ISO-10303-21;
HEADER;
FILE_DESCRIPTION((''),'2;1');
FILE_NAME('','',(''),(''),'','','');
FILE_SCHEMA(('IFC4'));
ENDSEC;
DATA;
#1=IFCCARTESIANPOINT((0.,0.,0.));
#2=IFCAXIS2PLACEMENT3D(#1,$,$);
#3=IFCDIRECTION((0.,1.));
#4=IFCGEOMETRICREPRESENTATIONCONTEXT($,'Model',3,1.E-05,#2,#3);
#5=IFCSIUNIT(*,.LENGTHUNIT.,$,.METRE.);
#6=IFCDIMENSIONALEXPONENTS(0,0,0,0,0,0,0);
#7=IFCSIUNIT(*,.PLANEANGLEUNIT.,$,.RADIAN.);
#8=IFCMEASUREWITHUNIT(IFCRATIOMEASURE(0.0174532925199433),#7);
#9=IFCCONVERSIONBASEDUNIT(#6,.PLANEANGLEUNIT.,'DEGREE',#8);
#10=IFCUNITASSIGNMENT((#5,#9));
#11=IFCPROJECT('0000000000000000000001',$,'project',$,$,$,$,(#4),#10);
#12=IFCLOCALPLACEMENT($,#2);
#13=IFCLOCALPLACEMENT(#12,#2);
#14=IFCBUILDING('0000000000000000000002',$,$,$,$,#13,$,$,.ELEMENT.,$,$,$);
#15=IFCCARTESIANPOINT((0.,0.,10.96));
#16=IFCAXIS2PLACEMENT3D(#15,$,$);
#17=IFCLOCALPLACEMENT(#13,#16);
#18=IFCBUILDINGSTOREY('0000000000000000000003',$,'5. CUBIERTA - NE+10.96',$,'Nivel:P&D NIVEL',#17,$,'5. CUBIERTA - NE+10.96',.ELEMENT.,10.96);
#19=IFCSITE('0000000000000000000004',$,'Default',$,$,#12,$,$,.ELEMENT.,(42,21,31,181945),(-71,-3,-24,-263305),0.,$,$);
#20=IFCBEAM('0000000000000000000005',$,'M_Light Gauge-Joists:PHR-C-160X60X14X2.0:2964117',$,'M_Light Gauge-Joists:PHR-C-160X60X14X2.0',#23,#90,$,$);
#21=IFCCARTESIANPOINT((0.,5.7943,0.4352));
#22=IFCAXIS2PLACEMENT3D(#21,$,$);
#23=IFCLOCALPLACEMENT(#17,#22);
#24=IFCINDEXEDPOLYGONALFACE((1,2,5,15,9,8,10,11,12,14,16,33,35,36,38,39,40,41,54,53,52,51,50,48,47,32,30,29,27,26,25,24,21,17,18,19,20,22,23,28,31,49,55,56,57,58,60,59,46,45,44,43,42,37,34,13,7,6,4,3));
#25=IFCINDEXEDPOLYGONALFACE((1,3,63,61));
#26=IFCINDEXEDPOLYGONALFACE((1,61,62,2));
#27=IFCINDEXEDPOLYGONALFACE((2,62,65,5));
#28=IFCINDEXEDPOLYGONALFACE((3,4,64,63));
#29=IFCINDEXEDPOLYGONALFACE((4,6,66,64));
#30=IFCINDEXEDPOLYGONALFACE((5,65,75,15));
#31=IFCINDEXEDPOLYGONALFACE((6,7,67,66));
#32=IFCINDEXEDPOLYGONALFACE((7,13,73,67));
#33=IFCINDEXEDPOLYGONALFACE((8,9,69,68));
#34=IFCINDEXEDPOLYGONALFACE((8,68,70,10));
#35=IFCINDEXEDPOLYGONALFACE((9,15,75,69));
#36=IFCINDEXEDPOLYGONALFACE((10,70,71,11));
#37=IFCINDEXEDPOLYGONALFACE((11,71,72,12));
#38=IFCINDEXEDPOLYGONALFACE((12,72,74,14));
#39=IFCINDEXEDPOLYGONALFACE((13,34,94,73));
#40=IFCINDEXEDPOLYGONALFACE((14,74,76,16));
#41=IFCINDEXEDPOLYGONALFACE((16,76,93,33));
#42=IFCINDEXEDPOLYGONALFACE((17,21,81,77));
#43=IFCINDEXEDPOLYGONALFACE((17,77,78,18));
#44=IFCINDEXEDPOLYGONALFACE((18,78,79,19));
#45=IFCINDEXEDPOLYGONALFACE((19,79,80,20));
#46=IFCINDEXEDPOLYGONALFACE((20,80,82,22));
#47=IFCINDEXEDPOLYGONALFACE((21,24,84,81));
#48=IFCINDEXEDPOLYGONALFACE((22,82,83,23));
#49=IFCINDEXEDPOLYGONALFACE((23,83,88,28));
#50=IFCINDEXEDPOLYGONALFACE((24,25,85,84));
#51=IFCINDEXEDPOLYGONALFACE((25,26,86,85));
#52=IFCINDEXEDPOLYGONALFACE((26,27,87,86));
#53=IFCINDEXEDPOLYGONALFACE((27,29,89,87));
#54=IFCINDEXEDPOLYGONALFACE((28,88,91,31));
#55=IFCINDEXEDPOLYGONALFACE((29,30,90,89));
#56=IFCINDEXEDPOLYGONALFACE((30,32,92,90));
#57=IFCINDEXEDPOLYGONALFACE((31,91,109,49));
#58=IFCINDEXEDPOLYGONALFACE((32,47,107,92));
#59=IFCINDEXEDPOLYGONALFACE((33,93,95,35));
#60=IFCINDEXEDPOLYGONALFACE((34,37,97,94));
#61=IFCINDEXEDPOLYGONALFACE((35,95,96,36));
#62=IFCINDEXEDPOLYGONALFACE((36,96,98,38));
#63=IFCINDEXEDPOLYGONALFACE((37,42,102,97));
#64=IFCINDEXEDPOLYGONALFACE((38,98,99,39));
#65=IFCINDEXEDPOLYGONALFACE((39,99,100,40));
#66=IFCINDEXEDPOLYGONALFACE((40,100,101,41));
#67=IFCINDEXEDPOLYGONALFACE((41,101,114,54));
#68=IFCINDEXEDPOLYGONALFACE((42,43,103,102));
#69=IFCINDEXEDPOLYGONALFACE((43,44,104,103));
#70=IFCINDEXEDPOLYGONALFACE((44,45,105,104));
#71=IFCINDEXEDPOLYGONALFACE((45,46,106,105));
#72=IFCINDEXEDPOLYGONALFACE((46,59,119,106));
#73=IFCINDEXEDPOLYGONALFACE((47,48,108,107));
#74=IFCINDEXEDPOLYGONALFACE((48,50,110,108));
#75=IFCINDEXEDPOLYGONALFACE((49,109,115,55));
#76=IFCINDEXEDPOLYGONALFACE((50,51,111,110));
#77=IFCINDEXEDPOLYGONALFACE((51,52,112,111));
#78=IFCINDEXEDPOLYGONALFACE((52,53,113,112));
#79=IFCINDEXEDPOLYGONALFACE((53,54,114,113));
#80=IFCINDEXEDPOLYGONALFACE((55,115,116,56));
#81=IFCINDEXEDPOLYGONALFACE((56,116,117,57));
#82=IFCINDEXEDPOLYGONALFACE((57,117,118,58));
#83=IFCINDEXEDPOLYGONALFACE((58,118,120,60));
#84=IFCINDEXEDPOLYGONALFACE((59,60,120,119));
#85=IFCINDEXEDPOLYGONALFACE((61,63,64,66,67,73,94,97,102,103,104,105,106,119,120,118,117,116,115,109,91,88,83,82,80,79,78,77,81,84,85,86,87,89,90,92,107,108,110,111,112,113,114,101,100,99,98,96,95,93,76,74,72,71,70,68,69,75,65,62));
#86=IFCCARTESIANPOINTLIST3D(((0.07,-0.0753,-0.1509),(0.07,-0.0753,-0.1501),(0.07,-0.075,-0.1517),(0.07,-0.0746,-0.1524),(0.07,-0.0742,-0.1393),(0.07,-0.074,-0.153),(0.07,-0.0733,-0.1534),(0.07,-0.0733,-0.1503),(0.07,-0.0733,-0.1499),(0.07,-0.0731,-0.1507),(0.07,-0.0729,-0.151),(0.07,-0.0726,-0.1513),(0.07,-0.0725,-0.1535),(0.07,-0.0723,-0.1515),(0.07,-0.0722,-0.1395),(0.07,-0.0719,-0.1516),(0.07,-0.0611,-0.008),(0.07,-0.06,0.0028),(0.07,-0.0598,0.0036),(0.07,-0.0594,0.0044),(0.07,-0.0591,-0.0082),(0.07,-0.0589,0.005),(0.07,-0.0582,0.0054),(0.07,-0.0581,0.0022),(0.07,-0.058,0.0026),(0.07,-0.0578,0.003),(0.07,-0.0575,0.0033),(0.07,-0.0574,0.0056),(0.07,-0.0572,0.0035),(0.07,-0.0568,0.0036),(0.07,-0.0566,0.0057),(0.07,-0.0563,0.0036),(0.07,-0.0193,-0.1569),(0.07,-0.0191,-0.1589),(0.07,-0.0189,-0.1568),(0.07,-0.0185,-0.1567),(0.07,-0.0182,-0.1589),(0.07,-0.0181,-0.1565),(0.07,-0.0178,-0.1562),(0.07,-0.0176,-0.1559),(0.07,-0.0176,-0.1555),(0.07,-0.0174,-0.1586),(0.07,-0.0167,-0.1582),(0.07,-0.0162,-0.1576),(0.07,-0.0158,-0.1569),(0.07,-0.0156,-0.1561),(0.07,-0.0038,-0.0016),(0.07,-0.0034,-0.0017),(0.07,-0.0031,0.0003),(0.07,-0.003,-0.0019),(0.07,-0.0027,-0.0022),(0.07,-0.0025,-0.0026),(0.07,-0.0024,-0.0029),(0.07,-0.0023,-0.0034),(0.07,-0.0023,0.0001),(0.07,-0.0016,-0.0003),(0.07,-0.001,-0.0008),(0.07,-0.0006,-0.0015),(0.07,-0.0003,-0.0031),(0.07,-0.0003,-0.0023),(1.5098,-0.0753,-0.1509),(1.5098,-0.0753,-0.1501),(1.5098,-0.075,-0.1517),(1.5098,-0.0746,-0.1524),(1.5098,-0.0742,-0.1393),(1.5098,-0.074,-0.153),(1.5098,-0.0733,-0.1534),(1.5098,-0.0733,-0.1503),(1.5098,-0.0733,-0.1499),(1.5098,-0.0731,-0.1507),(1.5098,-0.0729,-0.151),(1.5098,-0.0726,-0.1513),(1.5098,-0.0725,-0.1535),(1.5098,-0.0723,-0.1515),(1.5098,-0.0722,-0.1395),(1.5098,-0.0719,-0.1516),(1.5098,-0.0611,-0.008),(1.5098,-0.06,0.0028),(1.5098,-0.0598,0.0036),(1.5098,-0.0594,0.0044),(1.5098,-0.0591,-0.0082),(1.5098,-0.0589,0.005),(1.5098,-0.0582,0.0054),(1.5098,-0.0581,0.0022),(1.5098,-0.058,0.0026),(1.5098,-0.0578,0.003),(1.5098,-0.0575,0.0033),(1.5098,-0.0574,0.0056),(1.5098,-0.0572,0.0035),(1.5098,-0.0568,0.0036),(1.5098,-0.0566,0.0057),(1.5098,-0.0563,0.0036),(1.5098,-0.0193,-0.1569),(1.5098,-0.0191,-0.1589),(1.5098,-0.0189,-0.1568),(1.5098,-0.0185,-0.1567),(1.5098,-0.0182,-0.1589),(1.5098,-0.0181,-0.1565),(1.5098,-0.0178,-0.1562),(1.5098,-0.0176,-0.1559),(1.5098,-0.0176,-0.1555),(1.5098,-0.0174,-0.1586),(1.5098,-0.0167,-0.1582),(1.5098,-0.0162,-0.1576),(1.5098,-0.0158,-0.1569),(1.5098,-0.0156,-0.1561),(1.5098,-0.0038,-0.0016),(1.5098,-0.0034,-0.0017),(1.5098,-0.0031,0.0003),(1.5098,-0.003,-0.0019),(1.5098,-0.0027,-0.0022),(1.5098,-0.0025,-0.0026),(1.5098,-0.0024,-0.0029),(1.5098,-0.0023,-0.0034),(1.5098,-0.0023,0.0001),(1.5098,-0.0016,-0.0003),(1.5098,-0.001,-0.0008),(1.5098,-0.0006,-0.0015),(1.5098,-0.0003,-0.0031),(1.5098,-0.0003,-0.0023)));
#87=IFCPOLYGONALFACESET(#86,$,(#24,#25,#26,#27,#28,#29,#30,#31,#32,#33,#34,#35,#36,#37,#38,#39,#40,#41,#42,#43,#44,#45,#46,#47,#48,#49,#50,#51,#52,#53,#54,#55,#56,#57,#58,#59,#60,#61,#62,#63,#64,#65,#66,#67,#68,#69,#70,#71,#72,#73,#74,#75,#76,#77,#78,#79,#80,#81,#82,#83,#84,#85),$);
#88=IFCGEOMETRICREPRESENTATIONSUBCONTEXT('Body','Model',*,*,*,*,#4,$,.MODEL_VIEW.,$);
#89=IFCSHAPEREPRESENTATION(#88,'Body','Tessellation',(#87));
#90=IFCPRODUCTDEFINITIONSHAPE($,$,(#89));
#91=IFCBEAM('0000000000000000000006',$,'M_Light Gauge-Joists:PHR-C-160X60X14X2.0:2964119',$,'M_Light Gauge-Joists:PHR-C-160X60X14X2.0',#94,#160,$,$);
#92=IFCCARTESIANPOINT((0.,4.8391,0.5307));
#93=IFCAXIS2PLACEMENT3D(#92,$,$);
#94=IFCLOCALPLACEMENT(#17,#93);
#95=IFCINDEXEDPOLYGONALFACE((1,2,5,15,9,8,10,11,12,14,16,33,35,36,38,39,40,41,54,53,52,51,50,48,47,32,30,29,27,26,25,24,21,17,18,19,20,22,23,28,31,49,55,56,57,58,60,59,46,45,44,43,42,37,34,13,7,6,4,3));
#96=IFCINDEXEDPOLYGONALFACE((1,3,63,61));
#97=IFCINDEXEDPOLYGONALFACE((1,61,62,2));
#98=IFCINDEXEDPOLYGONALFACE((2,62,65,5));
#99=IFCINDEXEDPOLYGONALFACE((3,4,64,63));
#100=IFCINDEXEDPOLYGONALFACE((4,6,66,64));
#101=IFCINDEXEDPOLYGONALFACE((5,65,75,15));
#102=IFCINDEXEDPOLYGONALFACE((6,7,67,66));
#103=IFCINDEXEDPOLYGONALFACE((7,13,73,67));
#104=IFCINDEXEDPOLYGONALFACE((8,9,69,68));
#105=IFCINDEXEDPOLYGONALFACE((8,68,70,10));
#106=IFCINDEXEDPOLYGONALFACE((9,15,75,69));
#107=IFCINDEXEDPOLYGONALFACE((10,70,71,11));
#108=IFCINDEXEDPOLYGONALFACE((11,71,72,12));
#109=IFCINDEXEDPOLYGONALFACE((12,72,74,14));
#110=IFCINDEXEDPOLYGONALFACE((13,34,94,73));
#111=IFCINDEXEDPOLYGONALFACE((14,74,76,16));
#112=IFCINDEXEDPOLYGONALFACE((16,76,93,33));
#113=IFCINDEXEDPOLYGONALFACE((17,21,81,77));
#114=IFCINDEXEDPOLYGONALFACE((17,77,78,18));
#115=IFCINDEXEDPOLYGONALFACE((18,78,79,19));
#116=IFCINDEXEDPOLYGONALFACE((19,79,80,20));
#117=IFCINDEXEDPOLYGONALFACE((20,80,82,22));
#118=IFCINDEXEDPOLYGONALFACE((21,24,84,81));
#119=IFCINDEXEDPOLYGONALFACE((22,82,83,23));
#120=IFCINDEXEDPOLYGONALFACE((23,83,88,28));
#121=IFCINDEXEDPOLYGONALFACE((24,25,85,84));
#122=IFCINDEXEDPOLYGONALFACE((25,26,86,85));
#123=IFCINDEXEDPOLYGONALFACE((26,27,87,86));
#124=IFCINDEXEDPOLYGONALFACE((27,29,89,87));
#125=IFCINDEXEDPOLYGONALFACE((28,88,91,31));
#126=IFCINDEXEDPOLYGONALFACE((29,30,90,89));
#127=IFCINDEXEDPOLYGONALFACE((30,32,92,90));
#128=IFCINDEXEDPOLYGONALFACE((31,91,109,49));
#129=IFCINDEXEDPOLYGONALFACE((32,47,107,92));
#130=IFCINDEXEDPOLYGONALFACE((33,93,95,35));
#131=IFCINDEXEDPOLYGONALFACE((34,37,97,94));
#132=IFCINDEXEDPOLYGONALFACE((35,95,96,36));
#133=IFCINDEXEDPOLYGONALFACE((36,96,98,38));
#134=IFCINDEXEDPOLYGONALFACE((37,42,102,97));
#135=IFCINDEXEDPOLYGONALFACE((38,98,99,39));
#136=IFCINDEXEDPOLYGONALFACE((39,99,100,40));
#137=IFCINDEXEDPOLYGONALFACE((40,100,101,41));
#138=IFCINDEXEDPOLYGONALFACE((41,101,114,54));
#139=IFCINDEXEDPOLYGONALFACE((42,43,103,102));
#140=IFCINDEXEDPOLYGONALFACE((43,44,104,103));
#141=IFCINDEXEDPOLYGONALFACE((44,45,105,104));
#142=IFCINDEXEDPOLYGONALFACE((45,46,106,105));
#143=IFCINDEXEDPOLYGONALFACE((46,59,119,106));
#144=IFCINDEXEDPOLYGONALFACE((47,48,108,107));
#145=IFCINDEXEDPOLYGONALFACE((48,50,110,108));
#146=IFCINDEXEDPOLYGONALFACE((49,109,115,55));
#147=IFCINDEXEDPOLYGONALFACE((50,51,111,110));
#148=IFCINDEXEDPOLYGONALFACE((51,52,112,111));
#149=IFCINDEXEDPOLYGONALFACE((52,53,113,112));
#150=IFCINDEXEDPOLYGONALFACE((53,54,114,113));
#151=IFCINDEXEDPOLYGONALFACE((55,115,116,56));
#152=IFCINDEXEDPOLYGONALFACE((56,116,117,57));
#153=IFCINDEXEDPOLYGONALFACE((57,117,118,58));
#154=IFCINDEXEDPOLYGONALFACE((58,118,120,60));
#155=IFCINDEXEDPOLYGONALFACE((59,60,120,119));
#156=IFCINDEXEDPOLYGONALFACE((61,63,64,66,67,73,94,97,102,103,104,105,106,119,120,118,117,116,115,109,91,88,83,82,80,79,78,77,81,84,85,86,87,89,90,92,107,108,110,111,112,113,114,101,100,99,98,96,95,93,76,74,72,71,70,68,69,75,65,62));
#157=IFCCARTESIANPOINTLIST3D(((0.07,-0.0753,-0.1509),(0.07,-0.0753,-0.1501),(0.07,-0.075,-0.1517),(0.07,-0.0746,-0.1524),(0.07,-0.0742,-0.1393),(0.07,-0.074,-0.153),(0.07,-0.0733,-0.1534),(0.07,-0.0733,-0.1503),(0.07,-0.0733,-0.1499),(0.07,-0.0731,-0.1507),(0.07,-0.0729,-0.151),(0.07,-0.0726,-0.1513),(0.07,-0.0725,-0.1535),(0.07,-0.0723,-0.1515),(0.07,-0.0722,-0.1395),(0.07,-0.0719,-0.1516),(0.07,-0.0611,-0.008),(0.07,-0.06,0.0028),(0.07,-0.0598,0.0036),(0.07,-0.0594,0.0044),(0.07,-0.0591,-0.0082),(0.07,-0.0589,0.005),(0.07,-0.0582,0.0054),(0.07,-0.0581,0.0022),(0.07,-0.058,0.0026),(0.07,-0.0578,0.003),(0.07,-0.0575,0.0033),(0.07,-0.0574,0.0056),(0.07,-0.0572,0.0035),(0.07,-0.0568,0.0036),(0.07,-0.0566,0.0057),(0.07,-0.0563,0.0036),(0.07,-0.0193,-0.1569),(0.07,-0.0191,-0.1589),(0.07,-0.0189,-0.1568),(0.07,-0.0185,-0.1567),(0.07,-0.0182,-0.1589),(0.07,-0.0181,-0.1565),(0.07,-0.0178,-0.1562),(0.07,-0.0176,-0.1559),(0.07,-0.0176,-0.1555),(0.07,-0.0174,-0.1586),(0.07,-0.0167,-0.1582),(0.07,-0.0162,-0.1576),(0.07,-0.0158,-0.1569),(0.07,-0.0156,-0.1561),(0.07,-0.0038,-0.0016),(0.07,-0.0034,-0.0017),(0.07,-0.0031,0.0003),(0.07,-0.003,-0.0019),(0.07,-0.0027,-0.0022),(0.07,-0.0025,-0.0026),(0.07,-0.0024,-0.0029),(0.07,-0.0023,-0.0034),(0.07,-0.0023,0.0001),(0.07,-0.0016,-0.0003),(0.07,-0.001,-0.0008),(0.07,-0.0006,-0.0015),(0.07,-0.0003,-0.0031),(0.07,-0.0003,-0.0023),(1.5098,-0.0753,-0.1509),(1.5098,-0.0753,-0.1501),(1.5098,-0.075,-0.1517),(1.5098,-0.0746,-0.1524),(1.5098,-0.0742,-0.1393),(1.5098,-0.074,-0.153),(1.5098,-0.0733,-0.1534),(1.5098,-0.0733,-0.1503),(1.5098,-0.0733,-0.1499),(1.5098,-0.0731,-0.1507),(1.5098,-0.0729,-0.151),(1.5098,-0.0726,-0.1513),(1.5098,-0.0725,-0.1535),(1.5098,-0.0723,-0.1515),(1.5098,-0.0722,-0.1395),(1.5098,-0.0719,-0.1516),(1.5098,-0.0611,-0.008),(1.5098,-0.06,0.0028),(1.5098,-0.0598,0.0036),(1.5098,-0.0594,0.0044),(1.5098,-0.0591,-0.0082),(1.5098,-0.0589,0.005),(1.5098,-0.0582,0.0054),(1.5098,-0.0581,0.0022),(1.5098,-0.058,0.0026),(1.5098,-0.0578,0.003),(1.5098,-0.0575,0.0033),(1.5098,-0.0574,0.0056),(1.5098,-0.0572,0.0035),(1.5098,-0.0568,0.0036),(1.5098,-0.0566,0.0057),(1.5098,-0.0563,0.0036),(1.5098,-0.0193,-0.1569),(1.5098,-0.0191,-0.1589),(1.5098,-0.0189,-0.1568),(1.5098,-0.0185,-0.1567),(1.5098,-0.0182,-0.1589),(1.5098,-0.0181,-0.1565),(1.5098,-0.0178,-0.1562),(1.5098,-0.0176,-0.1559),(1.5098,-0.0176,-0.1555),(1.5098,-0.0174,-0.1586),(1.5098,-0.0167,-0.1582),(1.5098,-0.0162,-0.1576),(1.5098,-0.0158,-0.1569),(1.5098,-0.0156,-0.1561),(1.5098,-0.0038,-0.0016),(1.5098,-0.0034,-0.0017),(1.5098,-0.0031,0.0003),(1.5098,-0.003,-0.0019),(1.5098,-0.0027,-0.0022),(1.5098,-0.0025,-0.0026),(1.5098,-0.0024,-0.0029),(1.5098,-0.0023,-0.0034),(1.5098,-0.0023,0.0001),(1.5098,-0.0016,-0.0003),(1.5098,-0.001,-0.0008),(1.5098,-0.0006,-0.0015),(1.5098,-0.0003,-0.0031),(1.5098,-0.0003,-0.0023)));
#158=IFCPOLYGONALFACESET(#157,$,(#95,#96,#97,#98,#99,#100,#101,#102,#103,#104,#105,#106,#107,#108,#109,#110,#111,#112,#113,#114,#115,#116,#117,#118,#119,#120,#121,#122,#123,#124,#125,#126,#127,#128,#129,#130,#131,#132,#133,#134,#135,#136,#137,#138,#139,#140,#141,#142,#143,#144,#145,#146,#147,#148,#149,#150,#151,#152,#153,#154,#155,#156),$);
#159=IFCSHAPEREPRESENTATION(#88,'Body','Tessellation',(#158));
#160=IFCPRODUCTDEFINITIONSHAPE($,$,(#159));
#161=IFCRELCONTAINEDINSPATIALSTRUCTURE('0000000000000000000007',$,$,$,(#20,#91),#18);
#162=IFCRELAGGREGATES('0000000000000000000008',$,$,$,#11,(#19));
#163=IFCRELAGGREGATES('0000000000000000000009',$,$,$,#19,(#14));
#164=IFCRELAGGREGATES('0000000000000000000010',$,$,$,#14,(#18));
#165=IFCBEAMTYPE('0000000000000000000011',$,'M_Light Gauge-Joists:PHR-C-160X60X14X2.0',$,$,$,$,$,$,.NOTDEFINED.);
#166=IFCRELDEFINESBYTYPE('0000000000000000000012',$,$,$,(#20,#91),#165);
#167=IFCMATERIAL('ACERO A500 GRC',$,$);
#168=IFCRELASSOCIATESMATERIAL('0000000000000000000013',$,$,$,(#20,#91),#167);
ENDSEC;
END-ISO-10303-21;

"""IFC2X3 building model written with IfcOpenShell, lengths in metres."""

from ifc_helpers import new_model, entity, si_unit, converted_unit, direction, frame, frame_2d, origin, place, context, subcontext, project, spatial, polyline, circle_curve, parameter, trimmed, segment, composite_curve, outline, extrude, material, type_object, element, save


model = new_model("IFC2X3")

# Units and contexts
model_context = context("Model", 3, precision=1e-05, world=origin(), true_north=direction((0.0, 1.0)))
body_context = subcontext(model_context, "Body", "Model", "MODEL_VIEW")
ifc_project = project(units=[si_unit("LENGTHUNIT", "METRE"), converted_unit("PLANEANGLEUNIT", "DEGREE", entity("IfcRatioMeasure", 0.0174532925199433), si_unit("PLANEANGLEUNIT", "RADIAN"), dimensions=[0, 0, 0, 0, 0, 0, 0])], contexts=[model_context])

# Site, building, storey
site_placement = place(None, origin())
site = spatial("IfcSite", under=ifc_project, at=site_placement, Name="Default", CompositionType="ELEMENT", RefLatitude=(42, 21, 31, 181945), RefLongitude=(-71, -3, -24, -263305), RefElevation=0.0)
building_placement = place(site_placement, origin())
building = spatial("IfcBuilding", under=site, at=building_placement, CompositionType="ELEMENT")
storey_placement = place(building_placement, frame((0.0, 0.0, 10.96)))
storey = spatial("IfcBuildingStorey", under=building, at=storey_placement, Name="5. CUBIERTA - NE+10.96", ObjectType="Nivel:P&D NIVEL", LongName="5. CUBIERTA - NE+10.96", CompositionType="ELEMENT", Elevation=10.96)

# Beams
ifc_material_1 = material(Name="ACERO A500 GRC")
beam_type_1 = type_object("IfcBeamType", Name="M_Light Gauge-Joists:PHR-C-160X60X14X2.0", PredefinedType="NOTDEFINED")
beam_1_placement = place(storey_placement, frame((0.0, 5.7943, 0.4352)))
element("IfcBeam", 1, at=beam_1_placement, inside=storey, type_object=beam_type_1, material=ifc_material_1, Name="M_Light Gauge-Joists:PHR-C-160X60X14X2.0:2964117", ObjectType="M_Light Gauge-Joists:PHR-C-160X60X14X2.0", context=body_context, shape_type="SweptSolid", body=[
    extrude(outline(composite_curve([segment(polyline([(-0.0768, -0.0358), (0.0768, -0.0358)]), True, "CONTINUOUS"), segment(trimmed(circle_curve(frame_2d((0.0768, -0.0326), x_axis=(0.0, -1.0)), 0.0032), [parameter(0.0)], [parameter(90.0)], True, "PARAMETER"), True, "CONTINUOUS"), segment(polyline([(0.08, -0.0326), (0.08, 0.021)]), True, "CONTINUOUS"), segment(trimmed(circle_curve(frame_2d((0.0768, 0.021), x_axis=(1.0, 0.0)), 0.0032), [parameter(0.0)], [parameter(90.0)], True, "PARAMETER"), True, "CONTINUOUS"), segment(polyline([(0.0768, 0.0242), (0.066, 0.0242)]), True, "CONTINUOUS"), segment(polyline([(0.066, 0.0242), (0.066, 0.0222)]), True, "CONTINUOUS"), segment(polyline([(0.066, 0.0222), (0.0764, 0.0222)]), True, "CONTINUOUS"), segment(trimmed(circle_curve(frame_2d((0.0764, 0.0206), x_axis=(0.0, 1.0)), 0.0016), [parameter(270.0)], [parameter(0.0)], True, "PARAMETER"), False, "CONTINUOUS"), segment(polyline([(0.078, 0.0206), (0.078, -0.0322)]), True, "CONTINUOUS"), segment(trimmed(circle_curve(frame_2d((0.0764, -0.0322), x_axis=(1.0, 0.0)), 0.0016), [parameter(270.0)], [parameter(0.0)], True, "PARAMETER"), False, "CONTINUOUS"), segment(polyline([(0.0764, -0.0338), (-0.0764, -0.0338)]), True, "CONTINUOUS"), segment(trimmed(circle_curve(frame_2d((-0.0764, -0.0322), x_axis=(0.0, -1.0)), 0.0016), [parameter(270.0)], [parameter(0.0)], True, "PARAMETER"), False, "CONTINUOUS"), segment(polyline([(-0.078, -0.0322), (-0.078, 0.0206)]), True, "CONTINUOUS"), segment(trimmed(circle_curve(frame_2d((-0.0764, 0.0206), x_axis=(-1.0, 0.0)), 0.0016), [parameter(270.0)], [parameter(0.0)], True, "PARAMETER"), False, "CONTINUOUS"), segment(polyline([(-0.0764, 0.0222), (-0.066, 0.0222)]), True, "CONTINUOUS"), segment(polyline([(-0.066, 0.0222), (-0.066, 0.0242)]), True, "CONTINUOUS"), segment(polyline([(-0.066, 0.0242), (-0.0768, 0.0242)]), True, "CONTINUOUS"), segment(trimmed(circle_curve(frame_2d((-0.0768, 0.021), x_axis=(0.0, 1.0)), 0.0032), [parameter(0.0)], [parameter(90.0)], True, "PARAMETER"), True, "CONTINUOUS"), segment(polyline([(-0.08, 0.021), (-0.08, -0.0326)]), True, "CONTINUOUS"), segment(trimmed(circle_curve(frame_2d((-0.0768, -0.0326), x_axis=(-1.0, 0.0)), 0.0032), [parameter(0.0)], [parameter(90.0)], True, "PARAMETER"), True, "CONTINUOUS")], self_intersect=False)), frame((0.07, -0.0436, -0.076), z_axis=(1.0, 0.0, 0.0), x_axis=(0.0, 0.099504, 0.995037)), (0.0, 0.0, 1.0), 1.4398),
])
beam_2_placement = place(storey_placement, frame((0.0, 4.8391, 0.5307)))
element("IfcBeam", 2, at=beam_2_placement, inside=storey, type_object=beam_type_1, material=ifc_material_1, Name="M_Light Gauge-Joists:PHR-C-160X60X14X2.0:2964119", ObjectType="M_Light Gauge-Joists:PHR-C-160X60X14X2.0", context=body_context, shape_type="SweptSolid", body=[
    extrude(outline(composite_curve([segment(polyline([(-0.0768, -0.0358), (0.0768, -0.0358)]), True, "CONTINUOUS"), segment(trimmed(circle_curve(frame_2d((0.0768, -0.0326), x_axis=(0.0, -1.0)), 0.0032), [parameter(0.0)], [parameter(90.0)], True, "PARAMETER"), True, "CONTINUOUS"), segment(polyline([(0.08, -0.0326), (0.08, 0.021)]), True, "CONTINUOUS"), segment(trimmed(circle_curve(frame_2d((0.0768, 0.021), x_axis=(1.0, 0.0)), 0.0032), [parameter(0.0)], [parameter(90.0)], True, "PARAMETER"), True, "CONTINUOUS"), segment(polyline([(0.0768, 0.0242), (0.066, 0.0242)]), True, "CONTINUOUS"), segment(polyline([(0.066, 0.0242), (0.066, 0.0222)]), True, "CONTINUOUS"), segment(polyline([(0.066, 0.0222), (0.0764, 0.0222)]), True, "CONTINUOUS"), segment(trimmed(circle_curve(frame_2d((0.0764, 0.0206), x_axis=(0.0, 1.0)), 0.0016), [parameter(270.0)], [parameter(0.0)], True, "PARAMETER"), False, "CONTINUOUS"), segment(polyline([(0.078, 0.0206), (0.078, -0.0322)]), True, "CONTINUOUS"), segment(trimmed(circle_curve(frame_2d((0.0764, -0.0322), x_axis=(1.0, 0.0)), 0.0016), [parameter(270.0)], [parameter(0.0)], True, "PARAMETER"), False, "CONTINUOUS"), segment(polyline([(0.0764, -0.0338), (-0.0764, -0.0338)]), True, "CONTINUOUS"), segment(trimmed(circle_curve(frame_2d((-0.0764, -0.0322), x_axis=(0.0, -1.0)), 0.0016), [parameter(270.0)], [parameter(0.0)], True, "PARAMETER"), False, "CONTINUOUS"), segment(polyline([(-0.078, -0.0322), (-0.078, 0.0206)]), True, "CONTINUOUS"), segment(trimmed(circle_curve(frame_2d((-0.0764, 0.0206), x_axis=(-1.0, 0.0)), 0.0016), [parameter(270.0)], [parameter(0.0)], True, "PARAMETER"), False, "CONTINUOUS"), segment(polyline([(-0.0764, 0.0222), (-0.066, 0.0222)]), True, "CONTINUOUS"), segment(polyline([(-0.066, 0.0222), (-0.066, 0.0242)]), True, "CONTINUOUS"), segment(polyline([(-0.066, 0.0242), (-0.0768, 0.0242)]), True, "CONTINUOUS"), segment(trimmed(circle_curve(frame_2d((-0.0768, 0.021), x_axis=(0.0, 1.0)), 0.0032), [parameter(0.0)], [parameter(90.0)], True, "PARAMETER"), True, "CONTINUOUS"), segment(polyline([(-0.08, 0.021), (-0.08, -0.0326)]), True, "CONTINUOUS"), segment(trimmed(circle_curve(frame_2d((-0.0768, -0.0326), x_axis=(-1.0, 0.0)), 0.0032), [parameter(0.0)], [parameter(90.0)], True, "PARAMETER"), True, "CONTINUOUS")], self_intersect=False)), frame((0.07, -0.0436, -0.076), z_axis=(1.0, 0.0, 0.0), x_axis=(0.0, 0.099504, 0.995037)), (0.0, 0.0, 1.0), 1.4398),
])

save(model, "model.ifc")
